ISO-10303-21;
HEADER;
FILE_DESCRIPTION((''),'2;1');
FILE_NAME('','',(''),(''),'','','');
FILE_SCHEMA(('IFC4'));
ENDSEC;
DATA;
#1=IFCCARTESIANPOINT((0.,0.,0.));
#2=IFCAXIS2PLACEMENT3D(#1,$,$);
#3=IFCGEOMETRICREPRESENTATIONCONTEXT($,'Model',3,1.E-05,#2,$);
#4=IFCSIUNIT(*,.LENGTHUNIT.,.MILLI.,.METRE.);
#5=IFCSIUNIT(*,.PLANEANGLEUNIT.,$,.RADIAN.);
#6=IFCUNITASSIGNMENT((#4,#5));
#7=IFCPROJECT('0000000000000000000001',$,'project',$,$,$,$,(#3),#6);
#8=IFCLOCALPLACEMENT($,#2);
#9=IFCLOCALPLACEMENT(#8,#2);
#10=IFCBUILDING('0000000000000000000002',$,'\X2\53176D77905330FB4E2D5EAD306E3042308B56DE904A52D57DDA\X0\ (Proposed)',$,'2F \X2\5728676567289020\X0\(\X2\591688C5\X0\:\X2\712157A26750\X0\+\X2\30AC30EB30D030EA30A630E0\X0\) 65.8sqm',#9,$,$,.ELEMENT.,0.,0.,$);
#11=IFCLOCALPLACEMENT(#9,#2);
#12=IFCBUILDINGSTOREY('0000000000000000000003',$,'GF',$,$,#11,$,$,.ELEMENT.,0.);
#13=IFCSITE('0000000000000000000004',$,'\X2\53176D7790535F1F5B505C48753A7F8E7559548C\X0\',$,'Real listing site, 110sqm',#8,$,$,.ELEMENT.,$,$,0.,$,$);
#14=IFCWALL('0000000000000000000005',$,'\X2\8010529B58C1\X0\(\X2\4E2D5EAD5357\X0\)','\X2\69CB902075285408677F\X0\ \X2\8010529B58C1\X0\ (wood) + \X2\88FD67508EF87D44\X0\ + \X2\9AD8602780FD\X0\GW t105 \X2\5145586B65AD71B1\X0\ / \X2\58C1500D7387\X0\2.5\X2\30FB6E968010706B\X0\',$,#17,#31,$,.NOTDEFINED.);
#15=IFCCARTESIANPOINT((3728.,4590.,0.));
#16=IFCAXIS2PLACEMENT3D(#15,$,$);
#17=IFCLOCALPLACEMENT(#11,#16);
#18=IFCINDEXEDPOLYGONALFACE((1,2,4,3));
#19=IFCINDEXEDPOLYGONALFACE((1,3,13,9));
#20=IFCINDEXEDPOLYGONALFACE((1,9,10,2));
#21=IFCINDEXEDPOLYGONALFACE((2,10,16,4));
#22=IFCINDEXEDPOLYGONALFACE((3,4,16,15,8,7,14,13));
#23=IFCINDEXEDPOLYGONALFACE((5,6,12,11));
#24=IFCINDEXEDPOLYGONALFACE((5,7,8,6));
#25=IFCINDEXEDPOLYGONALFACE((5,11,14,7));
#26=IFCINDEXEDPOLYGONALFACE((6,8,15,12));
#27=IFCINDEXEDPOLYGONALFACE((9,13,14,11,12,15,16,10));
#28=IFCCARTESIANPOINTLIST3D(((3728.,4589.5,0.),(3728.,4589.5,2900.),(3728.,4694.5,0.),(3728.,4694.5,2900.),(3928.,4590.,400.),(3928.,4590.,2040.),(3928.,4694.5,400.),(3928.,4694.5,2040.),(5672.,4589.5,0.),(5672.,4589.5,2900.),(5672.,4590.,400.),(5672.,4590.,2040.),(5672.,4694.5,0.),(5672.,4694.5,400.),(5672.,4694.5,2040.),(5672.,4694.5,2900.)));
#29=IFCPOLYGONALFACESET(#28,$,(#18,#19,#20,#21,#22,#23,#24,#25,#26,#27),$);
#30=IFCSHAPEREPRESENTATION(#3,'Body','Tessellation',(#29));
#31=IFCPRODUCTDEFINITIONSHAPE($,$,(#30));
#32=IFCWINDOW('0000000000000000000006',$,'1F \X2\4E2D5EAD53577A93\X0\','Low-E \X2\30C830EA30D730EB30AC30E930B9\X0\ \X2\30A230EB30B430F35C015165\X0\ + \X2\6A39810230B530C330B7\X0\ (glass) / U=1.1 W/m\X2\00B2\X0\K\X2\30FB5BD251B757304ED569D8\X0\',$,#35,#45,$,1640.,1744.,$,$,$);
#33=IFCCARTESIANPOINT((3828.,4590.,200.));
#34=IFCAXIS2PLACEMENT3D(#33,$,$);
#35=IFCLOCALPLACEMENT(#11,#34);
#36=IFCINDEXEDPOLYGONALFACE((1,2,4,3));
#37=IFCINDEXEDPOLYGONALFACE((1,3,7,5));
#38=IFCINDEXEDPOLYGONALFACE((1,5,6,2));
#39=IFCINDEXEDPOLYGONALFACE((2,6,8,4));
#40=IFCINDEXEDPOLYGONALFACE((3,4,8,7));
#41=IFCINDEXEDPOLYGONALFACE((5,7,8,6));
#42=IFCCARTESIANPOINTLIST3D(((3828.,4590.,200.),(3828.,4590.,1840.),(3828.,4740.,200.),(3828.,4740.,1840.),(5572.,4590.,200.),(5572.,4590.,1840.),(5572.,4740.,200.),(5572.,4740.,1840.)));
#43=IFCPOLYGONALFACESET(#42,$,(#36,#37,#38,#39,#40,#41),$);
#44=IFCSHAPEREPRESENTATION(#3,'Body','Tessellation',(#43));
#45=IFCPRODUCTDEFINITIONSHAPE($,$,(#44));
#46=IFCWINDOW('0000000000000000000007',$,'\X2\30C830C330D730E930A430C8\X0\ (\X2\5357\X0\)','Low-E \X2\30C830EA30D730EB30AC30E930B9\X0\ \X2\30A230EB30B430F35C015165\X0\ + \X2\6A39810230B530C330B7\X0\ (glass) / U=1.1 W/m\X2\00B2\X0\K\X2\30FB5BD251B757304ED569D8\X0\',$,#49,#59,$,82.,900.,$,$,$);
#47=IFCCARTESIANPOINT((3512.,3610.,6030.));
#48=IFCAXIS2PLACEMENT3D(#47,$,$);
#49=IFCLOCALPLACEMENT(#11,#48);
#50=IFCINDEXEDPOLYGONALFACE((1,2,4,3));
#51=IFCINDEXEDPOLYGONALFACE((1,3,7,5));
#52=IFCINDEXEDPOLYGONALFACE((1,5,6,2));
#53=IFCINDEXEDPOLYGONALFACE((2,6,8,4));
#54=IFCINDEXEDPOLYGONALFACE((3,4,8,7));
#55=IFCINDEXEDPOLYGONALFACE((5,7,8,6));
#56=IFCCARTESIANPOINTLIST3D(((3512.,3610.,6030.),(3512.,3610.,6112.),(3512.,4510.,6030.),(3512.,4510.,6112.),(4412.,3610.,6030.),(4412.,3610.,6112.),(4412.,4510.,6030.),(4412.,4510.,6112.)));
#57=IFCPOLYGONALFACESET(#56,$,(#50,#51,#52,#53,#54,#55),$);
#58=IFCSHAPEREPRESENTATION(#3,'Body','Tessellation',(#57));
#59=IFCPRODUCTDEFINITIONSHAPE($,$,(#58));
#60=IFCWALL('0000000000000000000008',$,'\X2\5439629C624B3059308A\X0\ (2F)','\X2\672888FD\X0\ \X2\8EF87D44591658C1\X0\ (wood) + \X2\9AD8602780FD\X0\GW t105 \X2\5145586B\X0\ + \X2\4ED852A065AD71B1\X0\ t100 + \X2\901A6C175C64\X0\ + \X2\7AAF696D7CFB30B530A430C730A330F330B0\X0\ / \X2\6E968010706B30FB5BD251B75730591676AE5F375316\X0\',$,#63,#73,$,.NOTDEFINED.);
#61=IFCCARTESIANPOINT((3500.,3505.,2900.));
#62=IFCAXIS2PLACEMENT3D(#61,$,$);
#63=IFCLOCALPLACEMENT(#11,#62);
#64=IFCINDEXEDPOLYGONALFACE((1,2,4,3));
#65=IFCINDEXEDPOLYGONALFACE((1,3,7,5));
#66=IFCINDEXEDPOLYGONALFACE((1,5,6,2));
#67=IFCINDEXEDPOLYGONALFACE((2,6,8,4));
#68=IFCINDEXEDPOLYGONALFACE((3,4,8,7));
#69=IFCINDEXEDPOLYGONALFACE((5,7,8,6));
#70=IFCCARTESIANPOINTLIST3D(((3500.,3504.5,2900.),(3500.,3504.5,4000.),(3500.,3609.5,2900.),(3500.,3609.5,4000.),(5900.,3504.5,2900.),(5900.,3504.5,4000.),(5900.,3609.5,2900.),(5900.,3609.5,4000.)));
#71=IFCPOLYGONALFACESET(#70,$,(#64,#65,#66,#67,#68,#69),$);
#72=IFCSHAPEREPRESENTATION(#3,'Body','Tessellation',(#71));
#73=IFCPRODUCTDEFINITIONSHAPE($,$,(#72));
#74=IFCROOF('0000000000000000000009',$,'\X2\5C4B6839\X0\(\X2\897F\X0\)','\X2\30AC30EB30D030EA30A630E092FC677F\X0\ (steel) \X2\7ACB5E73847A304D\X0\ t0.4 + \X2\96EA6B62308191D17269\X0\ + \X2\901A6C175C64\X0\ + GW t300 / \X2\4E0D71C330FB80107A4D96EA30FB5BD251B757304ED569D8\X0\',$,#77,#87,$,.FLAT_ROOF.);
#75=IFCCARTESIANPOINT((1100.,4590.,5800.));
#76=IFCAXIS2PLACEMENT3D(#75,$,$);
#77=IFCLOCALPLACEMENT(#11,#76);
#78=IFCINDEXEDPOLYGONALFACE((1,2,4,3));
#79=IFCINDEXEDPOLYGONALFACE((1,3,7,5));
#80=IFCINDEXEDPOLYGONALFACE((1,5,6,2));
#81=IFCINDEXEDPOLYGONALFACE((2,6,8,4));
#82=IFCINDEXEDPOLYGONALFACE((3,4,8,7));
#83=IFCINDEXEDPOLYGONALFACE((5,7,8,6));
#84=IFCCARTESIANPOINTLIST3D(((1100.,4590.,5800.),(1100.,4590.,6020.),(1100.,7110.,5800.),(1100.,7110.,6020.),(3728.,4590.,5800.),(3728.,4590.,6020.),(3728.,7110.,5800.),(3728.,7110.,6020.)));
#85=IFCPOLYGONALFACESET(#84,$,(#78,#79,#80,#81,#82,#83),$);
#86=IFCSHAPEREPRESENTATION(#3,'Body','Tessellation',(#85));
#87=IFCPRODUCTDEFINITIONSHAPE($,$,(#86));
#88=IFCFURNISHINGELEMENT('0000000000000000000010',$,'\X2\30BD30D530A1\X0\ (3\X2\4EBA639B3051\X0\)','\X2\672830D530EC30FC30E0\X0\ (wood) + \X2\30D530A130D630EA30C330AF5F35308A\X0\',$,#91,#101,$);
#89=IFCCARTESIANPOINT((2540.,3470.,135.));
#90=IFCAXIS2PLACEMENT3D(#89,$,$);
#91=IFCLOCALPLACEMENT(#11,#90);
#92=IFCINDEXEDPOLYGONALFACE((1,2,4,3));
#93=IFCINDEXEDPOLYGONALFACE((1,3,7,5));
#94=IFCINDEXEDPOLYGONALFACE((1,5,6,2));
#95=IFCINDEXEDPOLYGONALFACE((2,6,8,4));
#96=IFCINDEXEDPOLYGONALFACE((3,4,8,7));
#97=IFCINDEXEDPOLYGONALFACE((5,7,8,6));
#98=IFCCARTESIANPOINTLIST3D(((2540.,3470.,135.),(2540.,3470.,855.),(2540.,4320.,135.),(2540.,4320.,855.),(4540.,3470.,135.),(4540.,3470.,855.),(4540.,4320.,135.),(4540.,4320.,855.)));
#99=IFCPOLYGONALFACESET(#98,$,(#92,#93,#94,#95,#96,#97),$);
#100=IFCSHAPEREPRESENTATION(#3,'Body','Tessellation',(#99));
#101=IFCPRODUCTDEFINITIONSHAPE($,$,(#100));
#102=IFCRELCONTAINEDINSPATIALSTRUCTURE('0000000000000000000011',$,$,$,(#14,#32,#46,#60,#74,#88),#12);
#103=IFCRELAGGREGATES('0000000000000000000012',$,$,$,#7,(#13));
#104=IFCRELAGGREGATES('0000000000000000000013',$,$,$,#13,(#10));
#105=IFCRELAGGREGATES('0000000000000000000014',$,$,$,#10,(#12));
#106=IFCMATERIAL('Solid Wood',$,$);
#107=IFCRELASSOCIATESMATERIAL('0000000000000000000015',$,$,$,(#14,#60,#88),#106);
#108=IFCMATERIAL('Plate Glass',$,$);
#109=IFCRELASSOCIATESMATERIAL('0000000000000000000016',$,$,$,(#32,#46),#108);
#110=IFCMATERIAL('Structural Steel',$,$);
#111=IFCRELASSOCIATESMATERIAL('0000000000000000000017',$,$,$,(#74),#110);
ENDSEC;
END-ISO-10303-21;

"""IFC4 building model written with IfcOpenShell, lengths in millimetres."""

from ifc_helpers import new_model, si_unit, frame, frame_2d, origin, place, context, project, spatial, rectangle, extrude, material, element, fill, save


model = new_model("IFC4")

# Units and contexts
model_context = context("Model", 3, precision=1e-05, world=origin())
ifc_project = project(units=[si_unit("LENGTHUNIT", "METRE", prefix="MILLI"), si_unit("PLANEANGLEUNIT", "RADIAN")], contexts=[model_context])

# Site, building, storey
site_placement = place(None, origin())
site = spatial("IfcSite", under=ifc_project, at=site_placement, Name="北海道弟子屈町美留和", ObjectType="Real listing site, 110sqm", CompositionType="ELEMENT", RefElevation=0.0)
building_placement = place(site_placement, origin())
building = spatial("IfcBuilding", under=site, at=building_placement, Name="北海道・中庭のある回遊動線 (Proposed)", ObjectType="2F 在来木造(外装:無垢材+ガルバリウム) 65.8sqm", CompositionType="ELEMENT", ElevationOfRefHeight=0.0, ElevationOfTerrain=0.0)
storey_placement = place(building_placement, origin())
storey = spatial("IfcBuildingStorey", under=building, at=storey_placement, Name="GF", CompositionType="ELEMENT", Elevation=0.0)

# Shared definitions
ifc_material_1 = material(Name="Solid Wood")

# Wall, opening, window
wall_1_placement = place(storey_placement, frame((3728.0, 4590.0, 0.0)))
wall_1 = element("IfcWall", 1, at=wall_1_placement, inside=storey, material=ifc_material_1, Name="耐力壁(中庭南)", Description="構造用合板 耐力壁 (wood) + 製材軸組 + 高性能GW t105 充填断熱 / 壁倍率2.5・準耐火", PredefinedType="NOTDEFINED", context=model_context, shape_type="SweptSolid", body=[
    extrude(rectangle(XDim=1944.0, YDim=105.0, at=frame_2d((972.0, 52.0))), frame((3728.0, 4590.0, 0.0)), (0.0, 0.0, 1.0), 2900.0),
])
opening_placement = place(storey_placement, frame((3828.0, 4590.0, 200.0)))
opening = element("IfcOpeningElement", 2, at=opening_placement, cuts=wall_1, PredefinedType="NOTDEFINED", context=model_context, shape_type="SweptSolid", body=[
    extrude(rectangle(XDim=1744.0, YDim=150.0, at=frame_2d((872.0, 75.0))), frame((3828.0, 4590.0, 200.0)), (0.0, 0.0, 1.0), 1640.0),
])
ifc_material_2 = material(Name="Plate Glass")
window_1_placement = place(storey_placement, frame((3828.0, 4590.0, 200.0)))
window_1 = element("IfcWindow", 3, at=window_1_placement, inside=storey, material=ifc_material_2, Name="1F 中庭南窓", Description="Low-E トリプルガラス アルゴン封入 + 樹脂サッシ (glass) / U=1.1 W/m²K・寒冷地仕様", OverallHeight=1640.0, OverallWidth=1744.0, context=model_context, shape_type="SweptSolid", body=[
    extrude(rectangle(XDim=1744.0, YDim=150.0, at=frame_2d((872.0, 75.0))), frame((3828.0, 4590.0, 200.0)), (0.0, 0.0, 1.0), 1640.0),
])
fill(opening, window_1)

# Window
window_2_placement = place(storey_placement, frame((3512.0, 3610.0, 6030.0)))
element("IfcWindow", 4, at=window_2_placement, inside=storey, material=ifc_material_2, Name="トップライト (南)", Description="Low-E トリプルガラス アルゴン封入 + 樹脂サッシ (glass) / U=1.1 W/m²K・寒冷地仕様", OverallHeight=82.0, OverallWidth=900.0, context=model_context, shape_type="SweptSolid", body=[
    extrude(rectangle(XDim=900.0, YDim=900.0, at=frame_2d((450.0, 450.0))), frame((3512.0, 3610.0, 6030.0)), (0.0, 0.0, 1.0), 82.0),
])

# Wall
wall_2_placement = place(storey_placement, frame((3500.0, 3505.0, 2900.0)))
element("IfcWall", 5, at=wall_2_placement, inside=storey, material=ifc_material_1, Name="吹抜手すり (2F)", Description="木製 軸組外壁 (wood) + 高性能GW t105 充填 + 付加断熱 t100 + 通気層 + 窯業系サイディング / 準耐火・寒冷地外皮強化", PredefinedType="NOTDEFINED", context=model_context, shape_type="SweptSolid", body=[
    extrude(rectangle(XDim=2400.0, YDim=105.0, at=frame_2d((1200.0, 52.0))), frame((3500.0, 3505.0, 2900.0)), (0.0, 0.0, 1.0), 1100.0),
])

# Roof
ifc_material_3 = material(Name="Structural Steel")
for number, where, name in (
    (6, (1100.0, 4590.0, 5800.0), "屋根(西)"),
):
    element("IfcRoof", number, at=place(storey_placement, frame(where)), inside=storey, material=ifc_material_3, Name=name, Description="ガルバリウム鋼板 (steel) 立平葺き t0.4 + 雪止め金物 + 通気層 + GW t300 / 不燃・耐積雪・寒冷地仕様", PredefinedType="FLAT_ROOF", context=model_context, shape_type="SweptSolid", body=[
        extrude(rectangle(XDim=2628.0, YDim=2520.0, at=frame_2d((1314.0, 1260.0))), frame((1100.0, 4590.0, 5800.0)), (0.0, 0.0, 1.0), 220.0),
    ])

# Furnishing element
furnishing_placement = place(storey_placement, frame((2540.0, 3470.0, 135.0)))
element("IfcFurnishingElement", 7, at=furnishing_placement, inside=storey, material=ifc_material_1, Name="ソファ (3人掛け)", Description="木フレーム (wood) + ファブリック張り", context=model_context, shape_type="SweptSolid", body=[
    extrude(rectangle(XDim=2000.0, YDim=850.0, at=frame_2d((1000.0, 425.0))), frame((2540.0, 3470.0, 135.0)), (0.0, 0.0, 1.0), 720.0),
])

save(model, "model.ifc")
